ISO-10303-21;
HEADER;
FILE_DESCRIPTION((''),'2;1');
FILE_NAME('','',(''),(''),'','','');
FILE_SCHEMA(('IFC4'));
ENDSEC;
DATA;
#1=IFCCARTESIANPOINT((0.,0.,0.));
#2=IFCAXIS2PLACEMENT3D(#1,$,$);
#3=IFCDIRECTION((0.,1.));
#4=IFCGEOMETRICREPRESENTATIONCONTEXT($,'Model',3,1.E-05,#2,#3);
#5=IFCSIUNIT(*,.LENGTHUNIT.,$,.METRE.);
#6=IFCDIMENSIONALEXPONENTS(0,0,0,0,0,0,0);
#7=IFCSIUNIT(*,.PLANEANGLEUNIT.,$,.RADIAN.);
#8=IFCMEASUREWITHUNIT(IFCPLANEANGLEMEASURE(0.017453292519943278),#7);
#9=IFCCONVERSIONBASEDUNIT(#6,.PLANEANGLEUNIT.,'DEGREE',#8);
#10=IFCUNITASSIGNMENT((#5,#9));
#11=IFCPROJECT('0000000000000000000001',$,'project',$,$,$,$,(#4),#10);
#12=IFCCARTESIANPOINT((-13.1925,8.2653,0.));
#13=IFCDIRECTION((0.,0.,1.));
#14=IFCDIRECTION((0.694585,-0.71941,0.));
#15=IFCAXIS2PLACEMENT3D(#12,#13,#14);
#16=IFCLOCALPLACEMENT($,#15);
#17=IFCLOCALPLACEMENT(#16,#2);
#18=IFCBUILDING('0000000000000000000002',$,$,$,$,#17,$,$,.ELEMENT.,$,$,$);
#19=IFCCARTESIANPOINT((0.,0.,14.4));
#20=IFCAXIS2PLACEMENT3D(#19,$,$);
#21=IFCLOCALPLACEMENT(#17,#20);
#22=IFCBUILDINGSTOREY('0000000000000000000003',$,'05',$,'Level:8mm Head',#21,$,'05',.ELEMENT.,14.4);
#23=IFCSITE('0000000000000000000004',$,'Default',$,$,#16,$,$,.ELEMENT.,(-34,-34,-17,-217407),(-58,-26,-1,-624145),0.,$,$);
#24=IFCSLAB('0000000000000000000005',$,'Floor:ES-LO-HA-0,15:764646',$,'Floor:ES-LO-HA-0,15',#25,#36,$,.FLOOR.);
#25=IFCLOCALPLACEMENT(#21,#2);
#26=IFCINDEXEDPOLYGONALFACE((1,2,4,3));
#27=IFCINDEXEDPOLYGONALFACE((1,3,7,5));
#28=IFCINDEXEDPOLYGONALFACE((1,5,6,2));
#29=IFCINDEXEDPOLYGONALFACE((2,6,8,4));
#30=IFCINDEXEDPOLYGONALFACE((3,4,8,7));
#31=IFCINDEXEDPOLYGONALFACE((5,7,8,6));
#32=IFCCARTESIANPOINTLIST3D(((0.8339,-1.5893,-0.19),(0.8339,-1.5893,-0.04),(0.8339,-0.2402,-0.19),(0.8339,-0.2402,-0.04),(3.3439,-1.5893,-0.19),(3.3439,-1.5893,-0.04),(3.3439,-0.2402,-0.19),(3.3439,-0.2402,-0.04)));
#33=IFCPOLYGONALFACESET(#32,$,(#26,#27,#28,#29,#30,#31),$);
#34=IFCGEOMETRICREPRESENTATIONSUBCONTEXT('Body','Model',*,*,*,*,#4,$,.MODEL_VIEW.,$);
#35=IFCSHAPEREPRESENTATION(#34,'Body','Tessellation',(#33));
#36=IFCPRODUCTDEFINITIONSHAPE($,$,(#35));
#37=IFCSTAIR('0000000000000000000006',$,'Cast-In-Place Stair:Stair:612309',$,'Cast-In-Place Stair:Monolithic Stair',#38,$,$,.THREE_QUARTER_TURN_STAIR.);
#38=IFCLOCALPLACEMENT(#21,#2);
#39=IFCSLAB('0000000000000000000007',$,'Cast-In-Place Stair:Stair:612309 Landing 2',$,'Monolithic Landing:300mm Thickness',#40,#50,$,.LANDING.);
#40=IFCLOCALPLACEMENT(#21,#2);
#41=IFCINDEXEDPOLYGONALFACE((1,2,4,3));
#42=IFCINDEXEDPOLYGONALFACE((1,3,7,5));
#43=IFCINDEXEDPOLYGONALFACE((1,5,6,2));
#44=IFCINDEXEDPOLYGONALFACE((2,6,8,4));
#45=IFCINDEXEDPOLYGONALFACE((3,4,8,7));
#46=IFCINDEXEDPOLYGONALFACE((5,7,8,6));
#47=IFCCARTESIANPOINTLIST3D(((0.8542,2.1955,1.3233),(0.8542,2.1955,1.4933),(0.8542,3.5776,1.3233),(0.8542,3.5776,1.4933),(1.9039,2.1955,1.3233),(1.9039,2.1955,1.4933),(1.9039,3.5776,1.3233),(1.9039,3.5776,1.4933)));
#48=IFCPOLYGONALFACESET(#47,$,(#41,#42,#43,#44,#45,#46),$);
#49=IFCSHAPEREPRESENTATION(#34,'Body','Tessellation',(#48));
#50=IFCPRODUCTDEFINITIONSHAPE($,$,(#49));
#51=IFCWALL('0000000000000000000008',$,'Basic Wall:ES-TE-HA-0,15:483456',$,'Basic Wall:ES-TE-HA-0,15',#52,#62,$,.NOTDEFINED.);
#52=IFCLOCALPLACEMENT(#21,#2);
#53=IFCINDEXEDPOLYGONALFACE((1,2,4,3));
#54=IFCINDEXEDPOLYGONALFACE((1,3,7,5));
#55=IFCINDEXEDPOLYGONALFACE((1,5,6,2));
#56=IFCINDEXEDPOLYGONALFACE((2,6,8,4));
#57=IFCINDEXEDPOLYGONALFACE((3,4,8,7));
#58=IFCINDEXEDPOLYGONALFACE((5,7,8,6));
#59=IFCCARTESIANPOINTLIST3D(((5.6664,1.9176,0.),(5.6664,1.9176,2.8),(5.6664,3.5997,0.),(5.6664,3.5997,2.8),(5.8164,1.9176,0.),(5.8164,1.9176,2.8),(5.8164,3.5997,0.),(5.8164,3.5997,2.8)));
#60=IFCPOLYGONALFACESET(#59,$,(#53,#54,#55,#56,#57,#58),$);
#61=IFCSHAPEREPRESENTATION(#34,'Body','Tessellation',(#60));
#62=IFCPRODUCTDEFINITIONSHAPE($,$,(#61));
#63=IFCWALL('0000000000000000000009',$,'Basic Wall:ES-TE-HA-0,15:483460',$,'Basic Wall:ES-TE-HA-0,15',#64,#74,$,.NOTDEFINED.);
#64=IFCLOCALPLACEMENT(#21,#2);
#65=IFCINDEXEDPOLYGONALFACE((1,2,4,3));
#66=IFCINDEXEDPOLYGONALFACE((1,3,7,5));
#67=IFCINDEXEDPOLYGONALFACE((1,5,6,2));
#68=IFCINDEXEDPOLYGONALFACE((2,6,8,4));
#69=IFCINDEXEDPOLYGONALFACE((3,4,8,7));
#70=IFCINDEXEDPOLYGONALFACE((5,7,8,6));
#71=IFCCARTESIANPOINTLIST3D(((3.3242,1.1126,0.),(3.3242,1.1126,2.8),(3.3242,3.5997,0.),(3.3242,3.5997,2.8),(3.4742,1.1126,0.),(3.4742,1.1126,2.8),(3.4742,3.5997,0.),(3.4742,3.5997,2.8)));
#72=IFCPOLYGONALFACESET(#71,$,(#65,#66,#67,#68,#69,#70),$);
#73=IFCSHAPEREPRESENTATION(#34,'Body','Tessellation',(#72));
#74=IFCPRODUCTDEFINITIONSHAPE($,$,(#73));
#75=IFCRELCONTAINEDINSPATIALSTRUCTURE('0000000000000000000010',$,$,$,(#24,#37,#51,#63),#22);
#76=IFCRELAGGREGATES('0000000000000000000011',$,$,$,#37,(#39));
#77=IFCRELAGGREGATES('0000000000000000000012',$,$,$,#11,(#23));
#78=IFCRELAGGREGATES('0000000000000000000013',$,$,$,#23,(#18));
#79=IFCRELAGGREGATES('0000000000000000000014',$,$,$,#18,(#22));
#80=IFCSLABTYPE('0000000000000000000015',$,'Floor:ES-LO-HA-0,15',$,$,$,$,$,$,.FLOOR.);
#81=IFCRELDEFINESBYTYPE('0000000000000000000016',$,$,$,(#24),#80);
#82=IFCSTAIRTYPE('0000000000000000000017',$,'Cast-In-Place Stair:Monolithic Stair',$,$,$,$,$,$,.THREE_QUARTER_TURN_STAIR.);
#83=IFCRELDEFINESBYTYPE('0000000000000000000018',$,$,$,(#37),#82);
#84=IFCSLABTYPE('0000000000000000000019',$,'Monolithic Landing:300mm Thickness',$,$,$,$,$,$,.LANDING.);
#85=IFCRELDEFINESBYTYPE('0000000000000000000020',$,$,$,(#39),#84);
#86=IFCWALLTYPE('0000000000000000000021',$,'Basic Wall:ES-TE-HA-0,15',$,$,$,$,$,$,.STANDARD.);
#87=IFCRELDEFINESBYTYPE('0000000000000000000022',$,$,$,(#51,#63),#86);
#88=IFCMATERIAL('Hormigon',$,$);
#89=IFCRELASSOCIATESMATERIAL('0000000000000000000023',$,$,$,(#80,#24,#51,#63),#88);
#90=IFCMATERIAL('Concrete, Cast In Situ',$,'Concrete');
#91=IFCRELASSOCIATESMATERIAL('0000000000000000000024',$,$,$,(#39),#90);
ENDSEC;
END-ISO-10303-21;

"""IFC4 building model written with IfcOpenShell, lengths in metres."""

from ifc_helpers import new_model, entity, si_unit, converted_unit, direction, frame, origin, place, context, subcontext, project, spatial, indexed_curve, outline, extrude, material, type_object, element, aggregate, save


model = new_model("IFC4")

# Units and contexts
model_context = context("Model", 3, precision=1e-05, world=origin(), true_north=direction((0.0, 1.0)))
body_context = subcontext(model_context, "Body", "Model", "MODEL_VIEW")
ifc_project = project(units=[si_unit("LENGTHUNIT", "METRE"), converted_unit("PLANEANGLEUNIT", "DEGREE", entity("IfcPlaneAngleMeasure", 0.017453292519943278), si_unit("PLANEANGLEUNIT", "RADIAN"), dimensions=[0, 0, 0, 0, 0, 0, 0])], contexts=[model_context])

# Site, building, storey
site_placement = place(None, frame((-13.1925, 8.2653, 0.0), z_axis=(0.0, 0.0, 1.0), x_axis=(0.694585, -0.71941, 0.0)))
site = spatial("IfcSite", under=ifc_project, at=site_placement, Name="Default", CompositionType="ELEMENT", RefLatitude=(-34, -34, -17, -217407), RefLongitude=(-58, -26, -1, -624145), RefElevation=0.0)
building_placement = place(site_placement, origin())
building = spatial("IfcBuilding", under=site, at=building_placement, CompositionType="ELEMENT")
storey_placement = place(building_placement, frame((0.0, 0.0, 14.4)))
storey = spatial("IfcBuildingStorey", under=building, at=storey_placement, Name="05", ObjectType="Level:8mm Head", LongName="05", CompositionType="ELEMENT", Elevation=14.4)

# Shared definitions
ifc_material_1 = material(Name="Hormigon")
slab_type_1 = type_object("IfcSlabType", Name="Floor:ES-LO-HA-0,15", PredefinedType="FLOOR", material=ifc_material_1)

# Slab
slab_1_placement = place(storey_placement, origin())
element("IfcSlab", 1, at=slab_1_placement, inside=storey, type_object=slab_type_1, material=ifc_material_1, Name="Floor:ES-LO-HA-0,15:764646", ObjectType="Floor:ES-LO-HA-0,15", PredefinedType="FLOOR", context=body_context, shape_type="SweptSolid", body=[
    extrude(outline(indexed_curve([(-0.6746, -1.255), (0.6746, -1.255), (0.6746, 1.255), (-0.6746, 1.255), (-0.6746, -1.255)], self_intersect=False)), frame((2.0889, -0.9147, -0.04), z_axis=(0.0, 0.0, -1.0), x_axis=(0.0, 1.0, 0.0)), (0.0, 0.0, 1.0), 0.15),
])

# Stair, slab
stair_type = type_object("IfcStairType", Name="Cast-In-Place Stair:Monolithic Stair", PredefinedType="THREE_QUARTER_TURN_STAIR")
stair_placement = place(storey_placement, origin())
stair = element("IfcStair", 2, at=stair_placement, inside=storey, type_object=stair_type, Name="Cast-In-Place Stair:Stair:612309", ObjectType="Cast-In-Place Stair:Monolithic Stair", PredefinedType="THREE_QUARTER_TURN_STAIR")
ifc_material_2 = material(Name="Concrete, Cast In Situ", Category="Concrete")
slab_type_2 = type_object("IfcSlabType", Name="Monolithic Landing:300mm Thickness", PredefinedType="LANDING")
slab_2_placement = place(stair_placement, origin())
slab_2 = element("IfcSlab", 3, at=slab_2_placement, type_object=slab_type_2, material=ifc_material_2, Name="Cast-In-Place Stair:Stair:612309 Landing 2", ObjectType="Monolithic Landing:300mm Thickness", PredefinedType="LANDING", context=body_context, shape_type="SweptSolid", body=[
    extrude(outline(indexed_curve([(-0.6911, -0.5249), (0.6911, -0.5249), (0.6911, 0.5249), (-0.6911, 0.5249), (-0.6911, -0.5249)], self_intersect=False)), frame((1.379, 2.8866, 1.3233), z_axis=(0.0, 0.0, 1.0), x_axis=(0.0, 1.0, 0.0)), (0.0, 0.0, 1.0), 0.17),
])

# Walls
wall_type = type_object("IfcWallType", Name="Basic Wall:ES-TE-HA-0,15", PredefinedType="STANDARD")
wall_1_placement = place(storey_placement, frame((5.7414, 1.9176, 0.0), z_axis=(0.0, 0.0, 1.0), x_axis=(0.0, 1.0, 0.0)))
element("IfcWall", 4, at=wall_1_placement, inside=storey, type_object=wall_type, material=ifc_material_1, Name="Basic Wall:ES-TE-HA-0,15:483456", ObjectType="Basic Wall:ES-TE-HA-0,15", PredefinedType="NOTDEFINED", context=body_context, shape_type="SweptSolid", body=[
    extrude(outline(indexed_curve([(1.682, 0.075), (0.0, 0.075), (0.0, -0.075), (1.682, -0.075), (1.682, 0.075)], self_intersect=False)), origin(), (0.0, 0.0, 1.0), 2.8),
])
wall_2_placement = place(storey_placement, frame((3.3992, 3.5997, 0.0), z_axis=(0.0, 0.0, 1.0), x_axis=(0.0, -1.0, 0.0)))
element("IfcWall", 5, at=wall_2_placement, inside=storey, type_object=wall_type, material=ifc_material_1, Name="Basic Wall:ES-TE-HA-0,15:483460", ObjectType="Basic Wall:ES-TE-HA-0,15", PredefinedType="NOTDEFINED", context=body_context, shape_type="SweptSolid", body=[
    extrude(outline(indexed_curve([(2.487, 0.075), (0.0, 0.075), (0.0, -0.075), (2.487, -0.075), (2.487, 0.075)], self_intersect=False)), origin(), (0.0, 0.0, 1.0), 2.8),
])

aggregate(stair, [slab_2])

save(model, "model.ifc")
